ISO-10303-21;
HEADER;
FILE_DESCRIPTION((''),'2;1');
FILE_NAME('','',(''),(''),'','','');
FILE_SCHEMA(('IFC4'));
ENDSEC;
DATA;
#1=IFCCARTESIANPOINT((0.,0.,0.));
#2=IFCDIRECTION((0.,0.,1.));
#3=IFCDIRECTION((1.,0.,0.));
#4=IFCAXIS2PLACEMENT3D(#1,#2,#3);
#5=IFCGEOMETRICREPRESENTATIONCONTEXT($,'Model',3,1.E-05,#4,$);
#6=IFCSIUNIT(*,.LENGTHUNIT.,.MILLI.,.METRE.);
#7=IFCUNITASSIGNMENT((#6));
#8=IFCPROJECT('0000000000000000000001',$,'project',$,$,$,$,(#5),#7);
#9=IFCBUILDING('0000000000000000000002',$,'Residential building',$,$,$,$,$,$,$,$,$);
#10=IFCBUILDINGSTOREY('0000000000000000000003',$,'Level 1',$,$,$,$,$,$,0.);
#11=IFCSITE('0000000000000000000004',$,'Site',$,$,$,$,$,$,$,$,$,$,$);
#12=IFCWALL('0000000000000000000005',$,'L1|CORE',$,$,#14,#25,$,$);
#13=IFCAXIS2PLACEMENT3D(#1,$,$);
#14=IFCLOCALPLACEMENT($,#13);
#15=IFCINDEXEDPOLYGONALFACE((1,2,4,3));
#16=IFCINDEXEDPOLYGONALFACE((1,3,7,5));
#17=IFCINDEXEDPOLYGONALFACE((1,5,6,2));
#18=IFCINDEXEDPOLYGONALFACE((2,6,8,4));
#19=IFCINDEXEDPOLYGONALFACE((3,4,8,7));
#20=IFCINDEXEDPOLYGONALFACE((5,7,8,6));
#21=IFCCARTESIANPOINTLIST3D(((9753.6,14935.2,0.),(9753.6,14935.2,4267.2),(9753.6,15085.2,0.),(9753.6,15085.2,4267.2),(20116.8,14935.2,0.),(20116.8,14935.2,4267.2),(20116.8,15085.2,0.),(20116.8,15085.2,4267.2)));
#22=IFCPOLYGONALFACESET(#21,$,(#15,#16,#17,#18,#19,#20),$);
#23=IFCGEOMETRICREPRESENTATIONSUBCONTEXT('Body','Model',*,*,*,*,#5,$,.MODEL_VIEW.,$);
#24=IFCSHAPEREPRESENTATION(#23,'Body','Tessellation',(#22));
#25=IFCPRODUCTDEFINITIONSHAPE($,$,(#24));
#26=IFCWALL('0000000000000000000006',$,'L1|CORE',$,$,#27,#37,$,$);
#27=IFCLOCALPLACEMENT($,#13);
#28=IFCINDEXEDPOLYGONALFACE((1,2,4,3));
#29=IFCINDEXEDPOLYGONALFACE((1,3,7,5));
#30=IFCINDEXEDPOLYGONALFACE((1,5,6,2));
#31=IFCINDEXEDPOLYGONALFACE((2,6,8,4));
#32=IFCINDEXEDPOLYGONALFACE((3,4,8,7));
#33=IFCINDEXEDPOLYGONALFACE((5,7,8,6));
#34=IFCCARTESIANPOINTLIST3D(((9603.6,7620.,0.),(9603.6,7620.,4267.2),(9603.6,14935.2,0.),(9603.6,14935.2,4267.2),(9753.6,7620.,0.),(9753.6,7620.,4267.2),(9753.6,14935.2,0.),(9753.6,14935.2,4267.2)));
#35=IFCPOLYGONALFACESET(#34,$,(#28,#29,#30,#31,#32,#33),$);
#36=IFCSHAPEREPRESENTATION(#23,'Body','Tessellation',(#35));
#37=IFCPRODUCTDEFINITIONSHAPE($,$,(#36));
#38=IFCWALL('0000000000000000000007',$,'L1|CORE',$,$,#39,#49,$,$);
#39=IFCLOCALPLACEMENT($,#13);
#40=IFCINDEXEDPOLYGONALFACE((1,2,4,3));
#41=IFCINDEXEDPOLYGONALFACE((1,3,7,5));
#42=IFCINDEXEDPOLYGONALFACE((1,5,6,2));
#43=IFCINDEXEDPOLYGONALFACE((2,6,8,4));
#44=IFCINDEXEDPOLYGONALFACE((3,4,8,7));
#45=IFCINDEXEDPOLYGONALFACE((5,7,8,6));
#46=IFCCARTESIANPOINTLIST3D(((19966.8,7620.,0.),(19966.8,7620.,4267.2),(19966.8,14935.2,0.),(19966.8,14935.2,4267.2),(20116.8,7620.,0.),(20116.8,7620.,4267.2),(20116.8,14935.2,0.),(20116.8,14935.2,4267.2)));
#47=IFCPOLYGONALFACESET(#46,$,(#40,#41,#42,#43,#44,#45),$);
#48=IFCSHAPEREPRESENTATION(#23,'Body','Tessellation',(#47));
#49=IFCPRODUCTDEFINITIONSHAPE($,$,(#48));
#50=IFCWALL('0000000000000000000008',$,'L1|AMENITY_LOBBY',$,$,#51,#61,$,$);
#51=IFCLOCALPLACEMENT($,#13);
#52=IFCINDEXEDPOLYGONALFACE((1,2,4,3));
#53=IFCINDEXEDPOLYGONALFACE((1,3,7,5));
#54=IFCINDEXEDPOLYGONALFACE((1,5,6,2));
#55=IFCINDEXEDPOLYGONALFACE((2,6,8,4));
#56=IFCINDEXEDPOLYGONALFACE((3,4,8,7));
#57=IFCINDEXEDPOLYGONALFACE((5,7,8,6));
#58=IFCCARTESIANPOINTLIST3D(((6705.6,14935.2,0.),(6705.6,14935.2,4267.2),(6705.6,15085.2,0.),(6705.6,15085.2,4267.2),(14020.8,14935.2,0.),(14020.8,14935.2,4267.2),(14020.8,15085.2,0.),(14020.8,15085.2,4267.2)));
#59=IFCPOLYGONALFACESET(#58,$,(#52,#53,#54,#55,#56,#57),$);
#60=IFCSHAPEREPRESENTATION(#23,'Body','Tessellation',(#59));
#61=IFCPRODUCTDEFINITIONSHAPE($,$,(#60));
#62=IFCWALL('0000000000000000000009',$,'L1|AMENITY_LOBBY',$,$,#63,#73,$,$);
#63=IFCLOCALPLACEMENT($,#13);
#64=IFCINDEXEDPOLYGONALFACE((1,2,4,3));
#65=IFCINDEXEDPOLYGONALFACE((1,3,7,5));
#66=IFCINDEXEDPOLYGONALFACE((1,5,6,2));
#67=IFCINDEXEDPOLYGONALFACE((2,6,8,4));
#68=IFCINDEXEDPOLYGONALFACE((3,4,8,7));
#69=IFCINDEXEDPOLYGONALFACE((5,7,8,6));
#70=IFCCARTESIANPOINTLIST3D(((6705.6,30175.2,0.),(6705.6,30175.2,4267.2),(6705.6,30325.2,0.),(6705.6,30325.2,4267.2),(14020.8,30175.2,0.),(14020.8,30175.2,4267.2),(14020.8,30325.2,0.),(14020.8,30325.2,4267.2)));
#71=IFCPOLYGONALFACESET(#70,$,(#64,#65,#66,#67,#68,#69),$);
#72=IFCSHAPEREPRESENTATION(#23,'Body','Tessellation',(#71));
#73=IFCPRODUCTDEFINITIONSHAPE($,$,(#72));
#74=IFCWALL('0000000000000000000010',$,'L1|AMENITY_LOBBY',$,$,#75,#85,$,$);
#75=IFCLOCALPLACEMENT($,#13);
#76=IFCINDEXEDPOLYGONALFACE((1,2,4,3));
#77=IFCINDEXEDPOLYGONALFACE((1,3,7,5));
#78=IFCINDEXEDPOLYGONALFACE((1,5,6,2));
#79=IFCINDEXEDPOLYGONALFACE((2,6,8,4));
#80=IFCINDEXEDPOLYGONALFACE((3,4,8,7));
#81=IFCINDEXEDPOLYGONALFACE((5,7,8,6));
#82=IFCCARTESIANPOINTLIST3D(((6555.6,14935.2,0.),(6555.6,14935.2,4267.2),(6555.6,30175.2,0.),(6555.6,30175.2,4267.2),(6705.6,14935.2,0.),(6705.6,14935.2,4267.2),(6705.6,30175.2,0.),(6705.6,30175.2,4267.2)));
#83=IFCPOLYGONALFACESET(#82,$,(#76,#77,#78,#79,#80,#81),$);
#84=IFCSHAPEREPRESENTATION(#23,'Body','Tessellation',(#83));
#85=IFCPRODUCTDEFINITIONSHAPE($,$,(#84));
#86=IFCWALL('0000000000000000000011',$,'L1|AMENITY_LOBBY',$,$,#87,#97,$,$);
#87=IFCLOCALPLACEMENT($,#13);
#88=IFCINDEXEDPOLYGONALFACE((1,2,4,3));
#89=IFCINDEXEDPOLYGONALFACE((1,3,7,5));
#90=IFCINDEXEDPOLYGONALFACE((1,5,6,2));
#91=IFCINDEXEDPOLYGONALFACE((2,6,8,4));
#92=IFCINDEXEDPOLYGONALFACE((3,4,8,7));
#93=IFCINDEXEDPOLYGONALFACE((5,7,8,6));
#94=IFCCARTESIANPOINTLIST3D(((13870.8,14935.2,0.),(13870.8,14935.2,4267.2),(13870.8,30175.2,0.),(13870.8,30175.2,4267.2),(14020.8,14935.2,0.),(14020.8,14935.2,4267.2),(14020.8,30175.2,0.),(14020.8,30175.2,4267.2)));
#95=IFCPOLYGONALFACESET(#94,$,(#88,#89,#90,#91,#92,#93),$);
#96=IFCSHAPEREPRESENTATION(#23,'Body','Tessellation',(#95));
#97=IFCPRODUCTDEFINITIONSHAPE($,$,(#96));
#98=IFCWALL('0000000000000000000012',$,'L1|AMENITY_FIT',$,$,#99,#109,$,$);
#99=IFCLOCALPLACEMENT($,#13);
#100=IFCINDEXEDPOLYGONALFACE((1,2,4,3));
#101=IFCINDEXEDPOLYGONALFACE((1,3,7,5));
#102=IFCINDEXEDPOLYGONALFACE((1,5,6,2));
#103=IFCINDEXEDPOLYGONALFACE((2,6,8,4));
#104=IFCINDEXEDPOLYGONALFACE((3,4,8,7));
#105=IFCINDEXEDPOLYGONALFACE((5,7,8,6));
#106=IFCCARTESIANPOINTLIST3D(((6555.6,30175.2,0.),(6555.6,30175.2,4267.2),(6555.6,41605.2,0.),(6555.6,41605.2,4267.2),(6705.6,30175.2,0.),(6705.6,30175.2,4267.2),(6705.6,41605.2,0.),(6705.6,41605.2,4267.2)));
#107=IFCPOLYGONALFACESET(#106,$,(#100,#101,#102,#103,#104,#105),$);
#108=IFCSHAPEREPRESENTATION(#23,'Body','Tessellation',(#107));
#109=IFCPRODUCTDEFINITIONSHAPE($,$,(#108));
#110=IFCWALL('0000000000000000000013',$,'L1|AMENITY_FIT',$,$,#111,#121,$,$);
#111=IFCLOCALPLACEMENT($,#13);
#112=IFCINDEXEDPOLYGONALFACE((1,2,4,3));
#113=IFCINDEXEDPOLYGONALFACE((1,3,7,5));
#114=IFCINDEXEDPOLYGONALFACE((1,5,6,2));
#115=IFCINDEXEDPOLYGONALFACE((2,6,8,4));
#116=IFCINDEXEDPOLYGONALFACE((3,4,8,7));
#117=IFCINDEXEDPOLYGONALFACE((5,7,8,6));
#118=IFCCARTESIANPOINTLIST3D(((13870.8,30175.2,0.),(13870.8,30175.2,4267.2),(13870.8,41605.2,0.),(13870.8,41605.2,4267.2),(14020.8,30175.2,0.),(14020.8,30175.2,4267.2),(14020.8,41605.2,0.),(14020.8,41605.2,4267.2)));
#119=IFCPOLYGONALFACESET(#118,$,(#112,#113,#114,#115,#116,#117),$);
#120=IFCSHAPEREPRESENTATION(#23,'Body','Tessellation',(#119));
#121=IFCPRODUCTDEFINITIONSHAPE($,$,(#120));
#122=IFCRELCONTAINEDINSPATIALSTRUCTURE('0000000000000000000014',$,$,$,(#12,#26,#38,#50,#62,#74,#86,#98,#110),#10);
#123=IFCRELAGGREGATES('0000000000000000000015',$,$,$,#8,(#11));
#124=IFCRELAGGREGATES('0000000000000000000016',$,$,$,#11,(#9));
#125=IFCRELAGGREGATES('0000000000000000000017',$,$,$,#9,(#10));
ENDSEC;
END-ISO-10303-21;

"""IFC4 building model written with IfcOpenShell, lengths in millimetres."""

from ifc_helpers import new_model, si_unit, frame, origin_with_axes, place, context, subcontext, project, spatial, indexed_curve, outline, extrude, element, save


model = new_model("IFC4")

# Units and contexts
model_context = context("Model", 3, precision=1e-05, world=origin_with_axes())
body_context = subcontext(model_context, "Body", "Model", "MODEL_VIEW")
ifc_project = project(units=[si_unit("LENGTHUNIT", "METRE", prefix="MILLI")], contexts=[model_context])

# Site, building, storey
site = spatial("IfcSite", under=ifc_project, Name="Site")
building = spatial("IfcBuilding", under=site, Name="Residential building")
storey = spatial("IfcBuildingStorey", under=building, Name="Level 1", Elevation=0.0)

# Walls
for number, where, z_axis, x_axis, name in (
    (1, (9753.6, 14935.2, 0.0), (0.0, 0.0, 1.0), (1.0, 0.0, 0.0), "L1|CORE"),
):
    element("IfcWall", number, at=place(None, frame(where, z_axis=z_axis, x_axis=x_axis)), inside=storey, Name=name, context=body_context, shape_type="SweptSolid", body=[
        extrude(outline(indexed_curve([(0.0, 0.0), (0.0, 150.0), (10363.2, 150.0), (10363.2, 0.0), (0.0, 0.0)], self_intersect=False)), origin_with_axes(), (0.0, 0.0, 1.0), 4267.2),
    ])
for number, where, z_axis, x_axis, name in (
    (2, (9753.6, 7620.0, 0.0), (0.0, 0.0, 1.0), (0.0, 1.0, 0.0), "L1|CORE"),
    (3, (20116.8, 7620.0, 0.0), (0.0, 0.0, 1.0), (0.0, 1.0, 0.0), "L1|CORE"),
    (4, (6705.6, 14935.2, 0.0), (0.0, 0.0, 1.0), (1.0, 0.0, 0.0), "L1|AMENITY_LOBBY"),
    (5, (6705.6, 30175.2, 0.0), (0.0, 0.0, 1.0), (1.0, 0.0, 0.0), "L1|AMENITY_LOBBY"),
):
    element("IfcWall", number, at=place(None, frame(where, z_axis=z_axis, x_axis=x_axis)), inside=storey, Name=name, context=body_context, shape_type="SweptSolid", body=[
        extrude(outline(indexed_curve([(0.0, 0.0), (0.0, 150.0), (7315.2, 150.0), (7315.2, 0.0), (0.0, 0.0)], self_intersect=False)), origin_with_axes(), (0.0, 0.0, 1.0), 4267.2),
    ])
for number, where, z_axis, x_axis, name in (
    (6, (6705.6, 14935.2, 0.0), (0.0, 0.0, 1.0), (0.0, 1.0, 0.0), "L1|AMENITY_LOBBY"),
    (7, (14020.8, 14935.2, 0.0), (0.0, 0.0, 1.0), (0.0, 1.0, 0.0), "L1|AMENITY_LOBBY"),
):
    element("IfcWall", number, at=place(None, frame(where, z_axis=z_axis, x_axis=x_axis)), inside=storey, Name=name, context=body_context, shape_type="SweptSolid", body=[
        extrude(outline(indexed_curve([(0.0, 0.0), (0.0, 150.0), (15240.0, 150.0), (15240.0, 0.0), (0.0, 0.0)], self_intersect=False)), origin_with_axes(), (0.0, 0.0, 1.0), 4267.2),
    ])
for number, where, z_axis, x_axis, name in (
    (8, (6705.6, 30175.2, 0.0), (0.0, 0.0, 1.0), (0.0, 1.0, 0.0), "L1|AMENITY_FIT"),
    (9, (14020.8, 30175.2, 0.0), (0.0, 0.0, 1.0), (0.0, 1.0, 0.0), "L1|AMENITY_FIT"),
):
    element("IfcWall", number, at=place(None, frame(where, z_axis=z_axis, x_axis=x_axis)), inside=storey, Name=name, context=body_context, shape_type="SweptSolid", body=[
        extrude(outline(indexed_curve([(0.0, 0.0), (0.0, 150.0), (11430.0, 150.0), (11430.0, 0.0), (0.0, 0.0)], self_intersect=False)), origin_with_axes(), (0.0, 0.0, 1.0), 4267.2),
    ])

save(model, "model.ifc")
